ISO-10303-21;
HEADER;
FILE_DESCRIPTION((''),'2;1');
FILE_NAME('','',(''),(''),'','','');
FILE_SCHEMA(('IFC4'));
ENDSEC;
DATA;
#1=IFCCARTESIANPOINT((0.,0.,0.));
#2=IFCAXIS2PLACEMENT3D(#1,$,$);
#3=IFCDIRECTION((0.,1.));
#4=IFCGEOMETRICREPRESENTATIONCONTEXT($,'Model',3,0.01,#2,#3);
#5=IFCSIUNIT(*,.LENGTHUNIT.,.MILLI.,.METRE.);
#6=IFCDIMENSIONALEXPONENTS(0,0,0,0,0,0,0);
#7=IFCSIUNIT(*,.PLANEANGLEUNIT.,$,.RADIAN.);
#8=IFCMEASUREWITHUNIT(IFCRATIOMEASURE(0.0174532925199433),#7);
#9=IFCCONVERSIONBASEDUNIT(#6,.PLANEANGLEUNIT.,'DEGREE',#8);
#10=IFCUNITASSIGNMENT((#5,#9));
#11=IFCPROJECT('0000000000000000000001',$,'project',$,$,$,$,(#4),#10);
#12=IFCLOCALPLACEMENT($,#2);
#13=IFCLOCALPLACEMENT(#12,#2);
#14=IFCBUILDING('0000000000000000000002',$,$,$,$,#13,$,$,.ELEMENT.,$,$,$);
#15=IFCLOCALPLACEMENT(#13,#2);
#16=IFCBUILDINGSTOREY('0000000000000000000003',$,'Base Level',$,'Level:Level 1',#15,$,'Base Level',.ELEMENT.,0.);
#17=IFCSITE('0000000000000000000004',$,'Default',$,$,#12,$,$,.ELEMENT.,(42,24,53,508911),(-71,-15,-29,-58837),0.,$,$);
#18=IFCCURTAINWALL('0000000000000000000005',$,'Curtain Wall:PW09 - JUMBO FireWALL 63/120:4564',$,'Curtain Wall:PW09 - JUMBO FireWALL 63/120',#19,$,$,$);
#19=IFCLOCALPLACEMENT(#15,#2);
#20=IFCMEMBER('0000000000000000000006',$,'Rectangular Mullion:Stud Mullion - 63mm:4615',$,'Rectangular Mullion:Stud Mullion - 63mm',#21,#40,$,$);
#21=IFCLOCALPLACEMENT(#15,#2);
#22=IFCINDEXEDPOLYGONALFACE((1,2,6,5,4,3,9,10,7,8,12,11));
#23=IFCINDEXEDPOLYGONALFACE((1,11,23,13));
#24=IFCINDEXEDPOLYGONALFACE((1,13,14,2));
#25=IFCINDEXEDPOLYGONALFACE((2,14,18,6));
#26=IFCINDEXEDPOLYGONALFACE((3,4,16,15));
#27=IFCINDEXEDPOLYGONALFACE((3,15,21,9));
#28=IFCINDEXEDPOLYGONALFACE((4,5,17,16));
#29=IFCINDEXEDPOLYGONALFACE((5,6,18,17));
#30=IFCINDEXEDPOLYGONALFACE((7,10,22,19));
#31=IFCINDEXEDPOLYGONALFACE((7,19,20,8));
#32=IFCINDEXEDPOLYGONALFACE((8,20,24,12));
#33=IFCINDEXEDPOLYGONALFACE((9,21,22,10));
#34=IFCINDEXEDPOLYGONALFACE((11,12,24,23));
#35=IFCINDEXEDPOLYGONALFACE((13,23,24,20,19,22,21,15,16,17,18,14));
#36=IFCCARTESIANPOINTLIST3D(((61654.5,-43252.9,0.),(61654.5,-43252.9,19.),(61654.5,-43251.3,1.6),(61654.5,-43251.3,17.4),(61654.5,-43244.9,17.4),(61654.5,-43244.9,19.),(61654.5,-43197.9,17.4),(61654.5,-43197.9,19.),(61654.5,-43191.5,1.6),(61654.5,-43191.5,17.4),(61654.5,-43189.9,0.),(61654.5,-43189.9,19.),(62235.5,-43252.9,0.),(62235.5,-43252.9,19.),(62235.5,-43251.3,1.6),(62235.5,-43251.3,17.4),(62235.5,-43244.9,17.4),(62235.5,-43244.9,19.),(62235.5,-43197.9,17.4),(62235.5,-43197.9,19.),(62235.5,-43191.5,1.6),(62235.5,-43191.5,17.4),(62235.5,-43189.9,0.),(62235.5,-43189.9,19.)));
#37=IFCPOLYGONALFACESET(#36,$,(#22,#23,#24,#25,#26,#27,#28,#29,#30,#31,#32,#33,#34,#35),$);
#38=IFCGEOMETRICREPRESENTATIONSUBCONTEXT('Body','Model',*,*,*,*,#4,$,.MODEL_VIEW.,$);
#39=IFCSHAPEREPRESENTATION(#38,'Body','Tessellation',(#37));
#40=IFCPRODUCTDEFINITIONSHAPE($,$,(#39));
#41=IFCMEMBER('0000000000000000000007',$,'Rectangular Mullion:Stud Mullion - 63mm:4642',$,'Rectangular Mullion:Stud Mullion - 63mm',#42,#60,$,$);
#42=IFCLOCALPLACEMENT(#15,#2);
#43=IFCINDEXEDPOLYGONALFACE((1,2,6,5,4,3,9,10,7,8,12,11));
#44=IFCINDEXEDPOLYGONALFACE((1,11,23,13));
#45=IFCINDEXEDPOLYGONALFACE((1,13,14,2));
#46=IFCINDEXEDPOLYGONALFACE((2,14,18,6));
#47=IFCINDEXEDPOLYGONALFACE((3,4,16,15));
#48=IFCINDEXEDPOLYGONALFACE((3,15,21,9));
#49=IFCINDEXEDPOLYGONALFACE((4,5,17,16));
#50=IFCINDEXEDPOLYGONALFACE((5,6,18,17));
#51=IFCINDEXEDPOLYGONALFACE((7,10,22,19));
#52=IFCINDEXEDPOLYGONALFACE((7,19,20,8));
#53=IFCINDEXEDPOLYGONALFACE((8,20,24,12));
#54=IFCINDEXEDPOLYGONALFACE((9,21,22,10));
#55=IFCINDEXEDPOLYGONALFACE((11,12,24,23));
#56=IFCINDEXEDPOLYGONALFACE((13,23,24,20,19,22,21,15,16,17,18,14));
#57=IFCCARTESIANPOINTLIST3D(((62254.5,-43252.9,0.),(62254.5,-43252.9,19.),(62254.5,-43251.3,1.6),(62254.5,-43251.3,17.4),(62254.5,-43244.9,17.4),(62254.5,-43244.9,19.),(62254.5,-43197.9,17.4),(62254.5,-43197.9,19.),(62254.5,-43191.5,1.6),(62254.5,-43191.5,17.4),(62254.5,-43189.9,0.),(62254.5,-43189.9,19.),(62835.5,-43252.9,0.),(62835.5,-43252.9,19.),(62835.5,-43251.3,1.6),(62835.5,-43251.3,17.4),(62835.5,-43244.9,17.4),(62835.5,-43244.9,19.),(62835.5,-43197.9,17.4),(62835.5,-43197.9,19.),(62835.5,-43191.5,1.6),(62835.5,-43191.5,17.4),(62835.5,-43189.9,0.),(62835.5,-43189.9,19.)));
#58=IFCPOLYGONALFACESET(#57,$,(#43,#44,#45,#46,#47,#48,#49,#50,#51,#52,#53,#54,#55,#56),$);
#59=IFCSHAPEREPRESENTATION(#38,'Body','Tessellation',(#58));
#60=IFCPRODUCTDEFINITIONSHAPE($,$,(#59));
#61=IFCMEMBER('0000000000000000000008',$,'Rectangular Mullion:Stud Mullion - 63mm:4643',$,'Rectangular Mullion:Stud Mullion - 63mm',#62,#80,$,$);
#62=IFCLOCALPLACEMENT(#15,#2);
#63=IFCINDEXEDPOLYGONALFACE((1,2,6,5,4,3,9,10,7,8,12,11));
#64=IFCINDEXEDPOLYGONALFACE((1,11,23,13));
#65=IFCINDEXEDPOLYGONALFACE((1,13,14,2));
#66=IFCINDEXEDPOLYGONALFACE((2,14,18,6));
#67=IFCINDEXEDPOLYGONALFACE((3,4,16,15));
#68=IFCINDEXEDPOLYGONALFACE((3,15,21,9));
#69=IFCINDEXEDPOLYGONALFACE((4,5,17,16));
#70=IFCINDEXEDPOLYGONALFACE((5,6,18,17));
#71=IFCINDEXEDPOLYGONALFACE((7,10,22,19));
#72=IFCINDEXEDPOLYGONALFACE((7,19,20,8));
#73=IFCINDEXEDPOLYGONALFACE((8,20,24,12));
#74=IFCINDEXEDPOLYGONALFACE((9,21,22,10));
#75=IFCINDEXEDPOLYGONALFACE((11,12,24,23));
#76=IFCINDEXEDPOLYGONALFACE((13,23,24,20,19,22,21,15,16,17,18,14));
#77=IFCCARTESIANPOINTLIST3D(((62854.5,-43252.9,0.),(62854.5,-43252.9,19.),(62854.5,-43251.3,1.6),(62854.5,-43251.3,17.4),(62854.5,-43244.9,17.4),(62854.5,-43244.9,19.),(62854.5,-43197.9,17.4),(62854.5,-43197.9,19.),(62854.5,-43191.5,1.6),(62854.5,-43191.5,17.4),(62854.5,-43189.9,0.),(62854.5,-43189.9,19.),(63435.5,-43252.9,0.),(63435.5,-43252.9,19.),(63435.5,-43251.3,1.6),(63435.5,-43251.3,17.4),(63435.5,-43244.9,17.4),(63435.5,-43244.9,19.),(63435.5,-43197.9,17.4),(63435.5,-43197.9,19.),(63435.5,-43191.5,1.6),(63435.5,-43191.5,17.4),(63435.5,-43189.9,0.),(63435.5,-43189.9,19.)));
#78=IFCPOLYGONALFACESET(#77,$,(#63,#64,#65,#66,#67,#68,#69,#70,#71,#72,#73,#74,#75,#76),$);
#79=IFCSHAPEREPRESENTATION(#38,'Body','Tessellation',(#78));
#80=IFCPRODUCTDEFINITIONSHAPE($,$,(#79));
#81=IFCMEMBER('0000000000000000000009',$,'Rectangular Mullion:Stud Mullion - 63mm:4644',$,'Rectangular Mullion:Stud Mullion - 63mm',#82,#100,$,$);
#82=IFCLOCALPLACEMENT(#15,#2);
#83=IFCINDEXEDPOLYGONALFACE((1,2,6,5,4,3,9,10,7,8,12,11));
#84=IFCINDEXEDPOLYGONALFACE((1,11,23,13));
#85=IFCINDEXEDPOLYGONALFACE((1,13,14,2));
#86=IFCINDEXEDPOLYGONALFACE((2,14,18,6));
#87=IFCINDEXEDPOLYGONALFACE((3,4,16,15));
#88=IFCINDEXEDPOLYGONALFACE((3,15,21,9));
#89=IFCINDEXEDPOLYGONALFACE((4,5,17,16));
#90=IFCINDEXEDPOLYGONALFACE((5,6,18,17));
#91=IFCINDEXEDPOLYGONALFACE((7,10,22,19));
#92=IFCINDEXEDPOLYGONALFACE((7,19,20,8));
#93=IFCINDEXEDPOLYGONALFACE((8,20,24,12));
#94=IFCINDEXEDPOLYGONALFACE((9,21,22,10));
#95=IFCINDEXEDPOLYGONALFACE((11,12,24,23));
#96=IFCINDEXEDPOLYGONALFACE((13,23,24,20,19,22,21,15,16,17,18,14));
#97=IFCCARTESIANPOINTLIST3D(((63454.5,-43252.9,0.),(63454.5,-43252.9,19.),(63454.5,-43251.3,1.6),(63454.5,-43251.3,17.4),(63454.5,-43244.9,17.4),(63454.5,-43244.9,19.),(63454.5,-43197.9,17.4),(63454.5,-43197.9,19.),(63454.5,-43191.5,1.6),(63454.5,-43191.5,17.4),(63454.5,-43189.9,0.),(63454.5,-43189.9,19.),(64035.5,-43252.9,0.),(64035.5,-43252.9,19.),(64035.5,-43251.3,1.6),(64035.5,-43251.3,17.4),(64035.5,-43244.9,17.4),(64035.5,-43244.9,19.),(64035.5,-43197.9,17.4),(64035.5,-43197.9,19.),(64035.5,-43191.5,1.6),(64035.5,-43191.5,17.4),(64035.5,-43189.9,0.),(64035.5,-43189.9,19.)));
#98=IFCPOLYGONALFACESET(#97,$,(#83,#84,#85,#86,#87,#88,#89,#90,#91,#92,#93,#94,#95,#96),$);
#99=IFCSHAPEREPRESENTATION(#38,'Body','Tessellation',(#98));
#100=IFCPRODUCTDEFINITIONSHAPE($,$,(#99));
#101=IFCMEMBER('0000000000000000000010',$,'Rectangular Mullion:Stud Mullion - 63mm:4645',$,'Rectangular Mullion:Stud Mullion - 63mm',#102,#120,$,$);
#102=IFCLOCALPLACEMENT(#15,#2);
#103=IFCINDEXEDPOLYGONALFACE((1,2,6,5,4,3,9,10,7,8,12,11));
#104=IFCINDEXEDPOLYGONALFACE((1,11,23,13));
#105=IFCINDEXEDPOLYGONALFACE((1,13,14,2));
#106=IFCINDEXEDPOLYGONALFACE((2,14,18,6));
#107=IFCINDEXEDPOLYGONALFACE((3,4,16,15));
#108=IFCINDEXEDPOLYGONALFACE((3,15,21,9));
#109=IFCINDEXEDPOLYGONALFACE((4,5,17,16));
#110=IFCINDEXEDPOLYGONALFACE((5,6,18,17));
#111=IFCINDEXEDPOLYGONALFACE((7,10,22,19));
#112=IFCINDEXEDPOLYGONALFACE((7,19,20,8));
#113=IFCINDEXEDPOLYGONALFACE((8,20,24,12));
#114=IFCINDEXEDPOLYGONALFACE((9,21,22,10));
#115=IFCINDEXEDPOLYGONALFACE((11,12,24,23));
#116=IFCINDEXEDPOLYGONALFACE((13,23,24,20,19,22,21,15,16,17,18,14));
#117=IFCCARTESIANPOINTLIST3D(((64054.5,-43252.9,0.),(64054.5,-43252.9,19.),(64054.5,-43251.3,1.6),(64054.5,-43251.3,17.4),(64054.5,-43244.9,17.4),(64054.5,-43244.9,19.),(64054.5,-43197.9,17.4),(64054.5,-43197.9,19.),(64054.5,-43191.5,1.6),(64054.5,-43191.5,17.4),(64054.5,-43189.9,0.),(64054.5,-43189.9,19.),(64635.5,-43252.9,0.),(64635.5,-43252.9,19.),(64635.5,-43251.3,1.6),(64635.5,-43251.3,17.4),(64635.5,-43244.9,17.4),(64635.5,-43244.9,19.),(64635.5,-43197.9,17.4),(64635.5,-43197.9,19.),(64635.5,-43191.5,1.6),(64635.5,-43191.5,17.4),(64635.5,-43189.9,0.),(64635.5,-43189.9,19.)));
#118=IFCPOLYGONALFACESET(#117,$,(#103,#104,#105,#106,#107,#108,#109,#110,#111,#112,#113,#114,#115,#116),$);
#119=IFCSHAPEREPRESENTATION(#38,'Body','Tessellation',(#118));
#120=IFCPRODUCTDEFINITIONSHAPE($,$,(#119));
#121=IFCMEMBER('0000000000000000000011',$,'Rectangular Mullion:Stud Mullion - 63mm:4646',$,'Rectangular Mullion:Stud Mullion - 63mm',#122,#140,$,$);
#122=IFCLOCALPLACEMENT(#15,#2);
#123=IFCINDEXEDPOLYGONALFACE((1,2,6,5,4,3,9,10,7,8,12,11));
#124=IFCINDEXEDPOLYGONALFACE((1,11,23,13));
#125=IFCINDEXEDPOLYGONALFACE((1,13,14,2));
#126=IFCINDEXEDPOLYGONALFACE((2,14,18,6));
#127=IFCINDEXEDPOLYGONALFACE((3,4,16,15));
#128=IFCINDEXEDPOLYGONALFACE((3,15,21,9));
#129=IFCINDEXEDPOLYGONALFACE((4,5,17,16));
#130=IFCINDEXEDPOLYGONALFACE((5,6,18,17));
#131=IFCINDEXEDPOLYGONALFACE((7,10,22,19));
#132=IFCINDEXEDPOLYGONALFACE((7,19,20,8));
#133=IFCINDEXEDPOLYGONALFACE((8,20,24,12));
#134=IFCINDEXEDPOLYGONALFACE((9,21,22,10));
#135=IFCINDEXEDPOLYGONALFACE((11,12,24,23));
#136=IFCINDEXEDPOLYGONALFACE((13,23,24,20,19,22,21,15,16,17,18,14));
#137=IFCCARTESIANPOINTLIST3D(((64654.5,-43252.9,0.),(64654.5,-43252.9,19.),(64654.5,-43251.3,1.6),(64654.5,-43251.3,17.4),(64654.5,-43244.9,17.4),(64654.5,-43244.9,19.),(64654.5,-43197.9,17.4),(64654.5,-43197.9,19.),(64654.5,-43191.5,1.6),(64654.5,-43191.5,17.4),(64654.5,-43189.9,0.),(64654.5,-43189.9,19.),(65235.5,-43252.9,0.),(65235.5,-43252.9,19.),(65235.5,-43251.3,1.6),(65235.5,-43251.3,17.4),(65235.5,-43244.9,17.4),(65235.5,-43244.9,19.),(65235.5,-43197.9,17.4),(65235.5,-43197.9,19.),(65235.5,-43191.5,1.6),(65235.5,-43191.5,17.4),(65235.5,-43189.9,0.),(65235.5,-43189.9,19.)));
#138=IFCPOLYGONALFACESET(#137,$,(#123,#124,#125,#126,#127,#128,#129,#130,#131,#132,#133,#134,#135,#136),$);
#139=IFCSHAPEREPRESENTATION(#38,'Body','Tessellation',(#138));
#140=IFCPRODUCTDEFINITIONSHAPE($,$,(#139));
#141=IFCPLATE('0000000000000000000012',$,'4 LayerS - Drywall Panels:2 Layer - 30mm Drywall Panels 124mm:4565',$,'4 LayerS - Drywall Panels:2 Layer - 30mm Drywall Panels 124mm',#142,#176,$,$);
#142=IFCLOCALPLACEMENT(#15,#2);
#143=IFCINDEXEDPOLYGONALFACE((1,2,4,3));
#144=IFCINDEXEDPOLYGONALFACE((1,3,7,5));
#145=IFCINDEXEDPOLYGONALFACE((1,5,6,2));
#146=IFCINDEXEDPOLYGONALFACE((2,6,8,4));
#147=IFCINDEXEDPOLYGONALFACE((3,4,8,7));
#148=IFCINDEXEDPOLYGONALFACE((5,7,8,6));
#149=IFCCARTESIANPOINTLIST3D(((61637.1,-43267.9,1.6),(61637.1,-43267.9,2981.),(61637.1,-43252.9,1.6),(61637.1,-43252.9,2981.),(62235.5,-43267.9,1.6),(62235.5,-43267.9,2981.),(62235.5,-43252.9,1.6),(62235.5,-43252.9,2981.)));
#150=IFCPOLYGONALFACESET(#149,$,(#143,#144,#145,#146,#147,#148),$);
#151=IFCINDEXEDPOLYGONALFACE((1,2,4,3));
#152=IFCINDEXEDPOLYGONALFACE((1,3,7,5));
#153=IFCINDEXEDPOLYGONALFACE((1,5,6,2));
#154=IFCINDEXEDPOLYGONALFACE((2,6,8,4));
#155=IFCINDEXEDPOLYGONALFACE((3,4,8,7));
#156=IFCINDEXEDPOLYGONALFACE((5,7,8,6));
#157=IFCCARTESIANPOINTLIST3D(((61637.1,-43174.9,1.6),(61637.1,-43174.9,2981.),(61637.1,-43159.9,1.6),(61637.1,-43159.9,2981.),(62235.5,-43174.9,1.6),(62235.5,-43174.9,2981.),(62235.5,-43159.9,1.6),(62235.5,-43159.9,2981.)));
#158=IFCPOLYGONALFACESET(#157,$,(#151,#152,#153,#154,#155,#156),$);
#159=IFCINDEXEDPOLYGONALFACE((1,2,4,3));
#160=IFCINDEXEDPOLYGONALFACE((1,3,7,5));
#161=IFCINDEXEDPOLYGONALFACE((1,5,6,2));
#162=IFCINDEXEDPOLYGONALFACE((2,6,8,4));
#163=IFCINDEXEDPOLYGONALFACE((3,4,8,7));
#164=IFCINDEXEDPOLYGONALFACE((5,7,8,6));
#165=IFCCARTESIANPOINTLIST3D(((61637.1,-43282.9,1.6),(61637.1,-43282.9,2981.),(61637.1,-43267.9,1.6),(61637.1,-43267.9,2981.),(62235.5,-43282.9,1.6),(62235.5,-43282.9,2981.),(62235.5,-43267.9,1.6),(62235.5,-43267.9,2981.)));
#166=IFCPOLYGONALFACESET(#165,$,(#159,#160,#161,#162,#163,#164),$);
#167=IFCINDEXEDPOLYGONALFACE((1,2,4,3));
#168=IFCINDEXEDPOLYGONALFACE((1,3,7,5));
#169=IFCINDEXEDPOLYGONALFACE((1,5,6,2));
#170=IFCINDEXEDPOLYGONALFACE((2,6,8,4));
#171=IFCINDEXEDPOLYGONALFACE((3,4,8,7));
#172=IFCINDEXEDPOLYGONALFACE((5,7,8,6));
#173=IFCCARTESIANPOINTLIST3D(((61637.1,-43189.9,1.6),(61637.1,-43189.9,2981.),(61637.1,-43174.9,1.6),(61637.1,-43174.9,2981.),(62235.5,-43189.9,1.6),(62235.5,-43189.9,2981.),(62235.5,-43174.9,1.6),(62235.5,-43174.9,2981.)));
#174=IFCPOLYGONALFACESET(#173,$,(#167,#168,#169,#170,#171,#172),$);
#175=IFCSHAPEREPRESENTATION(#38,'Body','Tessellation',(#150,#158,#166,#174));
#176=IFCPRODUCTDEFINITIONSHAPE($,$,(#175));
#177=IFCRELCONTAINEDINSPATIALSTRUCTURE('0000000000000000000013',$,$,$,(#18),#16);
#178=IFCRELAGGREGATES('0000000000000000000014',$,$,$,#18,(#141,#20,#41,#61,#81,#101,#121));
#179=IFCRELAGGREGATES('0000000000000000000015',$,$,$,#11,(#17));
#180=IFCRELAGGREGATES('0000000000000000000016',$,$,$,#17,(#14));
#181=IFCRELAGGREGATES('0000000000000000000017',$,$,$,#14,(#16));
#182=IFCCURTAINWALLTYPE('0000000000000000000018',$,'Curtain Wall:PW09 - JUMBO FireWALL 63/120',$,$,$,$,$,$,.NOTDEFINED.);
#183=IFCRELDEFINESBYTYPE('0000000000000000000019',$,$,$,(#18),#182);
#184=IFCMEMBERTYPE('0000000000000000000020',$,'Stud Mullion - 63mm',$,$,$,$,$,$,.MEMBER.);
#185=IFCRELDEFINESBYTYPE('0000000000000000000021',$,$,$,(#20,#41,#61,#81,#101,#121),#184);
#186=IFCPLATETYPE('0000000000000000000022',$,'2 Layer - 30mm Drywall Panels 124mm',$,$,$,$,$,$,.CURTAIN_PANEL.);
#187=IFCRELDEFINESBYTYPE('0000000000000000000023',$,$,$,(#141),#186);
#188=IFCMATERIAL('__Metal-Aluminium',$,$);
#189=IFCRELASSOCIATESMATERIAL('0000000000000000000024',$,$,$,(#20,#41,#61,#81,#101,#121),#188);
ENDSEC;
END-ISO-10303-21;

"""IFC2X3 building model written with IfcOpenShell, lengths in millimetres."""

from ifc_helpers import new_model, entity, si_unit, converted_unit, direction, frame, frame_2d, origin, origin_2d_with_axis, place, context, subcontext, project, spatial, polyline, rectangle, outline, extrude, source, transform, mapped, material, type_object, type_shapes, element, aggregate, save


model = new_model("IFC2X3")

# Units and contexts
model_context = context("Model", 3, precision=0.01, world=origin(), true_north=direction((0.0, 1.0)))
body_context = subcontext(model_context, "Body", "Model", "MODEL_VIEW")
ifc_project = project(units=[si_unit("LENGTHUNIT", "METRE", prefix="MILLI"), converted_unit("PLANEANGLEUNIT", "DEGREE", entity("IfcRatioMeasure", 0.0174532925199433), si_unit("PLANEANGLEUNIT", "RADIAN"), dimensions=[0, 0, 0, 0, 0, 0, 0])], contexts=[model_context])

# Site, building, storey
site_placement = place(None, origin())
site = spatial("IfcSite", under=ifc_project, at=site_placement, Name="Default", CompositionType="ELEMENT", RefLatitude=(42, 24, 53, 508911), RefLongitude=(-71, -15, -29, -58837), RefElevation=0.0)
building_placement = place(site_placement, origin())
building = spatial("IfcBuilding", under=site, at=building_placement, CompositionType="ELEMENT")
storey_placement = place(building_placement, origin())
storey = spatial("IfcBuildingStorey", under=building, at=storey_placement, Name="Base Level", ObjectType="Level:Level 1", LongName="Base Level", CompositionType="ELEMENT", Elevation=0.0)

# Curtain wall, members, plate
curtain_wall_type = type_object("IfcCurtainWallType", Name="Curtain Wall:PW09 - JUMBO FireWALL 63/120", PredefinedType="NOTDEFINED")
curtain_wall_placement = place(building_placement, origin())
curtain_wall = element("IfcCurtainWall", 1, at=curtain_wall_placement, inside=storey, type_object=curtain_wall_type, Name="Curtain Wall:PW09 - JUMBO FireWALL 63/120:4564", ObjectType="Curtain Wall:PW09 - JUMBO FireWALL 63/120")
ifc_material_1 = material(Name="__Metal-Aluminium")
member_type_1 = type_object("IfcMemberType", Name="Stud Mullion - 63mm", PredefinedType="MEMBER")
shared_shape_1 = source(origin(), body_context, "Body", "SweptSolid", [
    extrude(outline(polyline([(23.5, -6.6), (31.5, -6.6), (31.5, 12.4), (-31.5, 12.4), (-31.5, -6.6), (-23.5, -6.6), (-23.5, -5.0), (-29.9, -5.0), (-29.9, 10.8), (29.9, 10.8), (29.9, -5.0), (23.5, -5.0), (23.5, -6.6)])), frame((-12.4, 0.0, -581.0), z_axis=(0.0, 0.0, 1.0), x_axis=(0.0, -1.0, 0.0)), (0.0, 0.0, 1.0), 581.0),
])
type_shapes(member_type_1, [shared_shape_1])
member_1_placement = place(building_placement, frame((61654.5, -43221.4, 0.0), z_axis=(-1.0, 0.0, 0.0), x_axis=(0.0, 0.0, -1.0)))
member_1 = element("IfcMember", 2, at=member_1_placement, type_object=member_type_1, material=ifc_material_1, Name="Rectangular Mullion:Stud Mullion - 63mm:4615", ObjectType="Rectangular Mullion:Stud Mullion - 63mm", context=body_context, shape_type="MappedRepresentation", body=[
    mapped(shared_shape_1, transform((0.0, 0.0, 0.0), scale=1.0)),
])
member_2_placement = place(building_placement, frame((62254.5, -43221.4, 0.0), z_axis=(-1.0, 0.0, 0.0), x_axis=(0.0, 0.0, -1.0)))
member_2 = element("IfcMember", 3, at=member_2_placement, type_object=member_type_1, material=ifc_material_1, Name="Rectangular Mullion:Stud Mullion - 63mm:4642", ObjectType="Rectangular Mullion:Stud Mullion - 63mm", context=body_context, shape_type="MappedRepresentation", body=[
    mapped(shared_shape_1, transform((0.0, 0.0, 0.0), scale=1.0)),
])
member_3_placement = place(building_placement, frame((62854.5, -43221.4, 0.0), z_axis=(-1.0, 0.0, 0.0), x_axis=(0.0, 0.0, -1.0)))
member_3 = element("IfcMember", 4, at=member_3_placement, type_object=member_type_1, material=ifc_material_1, Name="Rectangular Mullion:Stud Mullion - 63mm:4643", ObjectType="Rectangular Mullion:Stud Mullion - 63mm", context=body_context, shape_type="MappedRepresentation", body=[
    mapped(shared_shape_1, transform((0.0, 0.0, 0.0), scale=1.0)),
])
member_4_placement = place(building_placement, frame((63454.5, -43221.4, 0.0), z_axis=(-1.0, 0.0, 0.0), x_axis=(0.0, 0.0, -1.0)))
member_4 = element("IfcMember", 5, at=member_4_placement, type_object=member_type_1, material=ifc_material_1, Name="Rectangular Mullion:Stud Mullion - 63mm:4644", ObjectType="Rectangular Mullion:Stud Mullion - 63mm", context=body_context, shape_type="MappedRepresentation", body=[
    mapped(shared_shape_1, transform((0.0, 0.0, 0.0), scale=1.0)),
])
member_5_placement = place(building_placement, frame((64054.5, -43221.4, 0.0), z_axis=(-1.0, 0.0, 0.0), x_axis=(0.0, 0.0, -1.0)))
member_5 = element("IfcMember", 6, at=member_5_placement, type_object=member_type_1, material=ifc_material_1, Name="Rectangular Mullion:Stud Mullion - 63mm:4645", ObjectType="Rectangular Mullion:Stud Mullion - 63mm", context=body_context, shape_type="MappedRepresentation", body=[
    mapped(shared_shape_1, transform((0.0, 0.0, 0.0), scale=1.0)),
])
member_6_placement = place(building_placement, frame((64654.5, -43221.4, 0.0), z_axis=(-1.0, 0.0, 0.0), x_axis=(0.0, 0.0, -1.0)))
member_6 = element("IfcMember", 7, at=member_6_placement, type_object=member_type_1, material=ifc_material_1, Name="Rectangular Mullion:Stud Mullion - 63mm:4646", ObjectType="Rectangular Mullion:Stud Mullion - 63mm", context=body_context, shape_type="MappedRepresentation", body=[
    mapped(shared_shape_1, transform((0.0, 0.0, 0.0), scale=1.0)),
])
plate_type = type_object("IfcPlateType", Name="2 Layer - 30mm Drywall Panels 124mm", PredefinedType="CURTAIN_PANEL")
shared_shape_2 = source(origin(), body_context, "Body", "SweptSolid", [
    extrude(rectangle(XDim=15.0, YDim=598.4, at=origin_2d_with_axis()), frame((0.0, -39.0, 0.0), z_axis=(0.0, 0.0, 1.0), x_axis=(0.0, 1.0, 0.0)), (0.0, 0.0, 1.0), 2979.4),
    extrude(rectangle(XDim=15.0, YDim=598.4, at=origin_2d_with_axis()), frame((0.0, 54.0, 0.0), z_axis=(0.0, 0.0, 1.0), x_axis=(0.0, 1.0, 0.0)), (0.0, 0.0, 1.0), 2979.4),
    extrude(rectangle(XDim=598.4, YDim=15.0, at=frame_2d((0.0, 0.0), x_axis=(1.0, 0.0))), frame((0.0, -54.0, 0.0), z_axis=(0.0, 0.0, 1.0), x_axis=(-1.0, 0.0, 0.0)), (0.0, 0.0, 1.0), 2979.4),
    extrude(rectangle(XDim=15.0, YDim=598.4, at=frame_2d((0.0, 0.0), x_axis=(1.0, 0.0))), frame((0.0, 39.0, 0.0), z_axis=(0.0, 0.0, 1.0), x_axis=(0.0, 1.0, 0.0)), (0.0, 0.0, 1.0), 2979.4),
])
type_shapes(plate_type, [shared_shape_2])
plate_1_placement = place(curtain_wall_placement, frame((61936.3, -43221.4, 1.6)))
plate_1 = element("IfcPlate", 8, at=plate_1_placement, type_object=plate_type, Name="4 LayerS - Drywall Panels:2 Layer - 30mm Drywall Panels 124mm:4565", ObjectType="4 LayerS - Drywall Panels:2 Layer - 30mm Drywall Panels 124mm", context=body_context, shape_type="MappedRepresentation", body=[
    mapped(shared_shape_2, transform((0.0, 0.0, 0.0), scale=1.0)),
])
aggregate(curtain_wall, [plate_1, member_1, member_2, member_3, member_4, member_5, member_6])

save(model, "model.ifc")
